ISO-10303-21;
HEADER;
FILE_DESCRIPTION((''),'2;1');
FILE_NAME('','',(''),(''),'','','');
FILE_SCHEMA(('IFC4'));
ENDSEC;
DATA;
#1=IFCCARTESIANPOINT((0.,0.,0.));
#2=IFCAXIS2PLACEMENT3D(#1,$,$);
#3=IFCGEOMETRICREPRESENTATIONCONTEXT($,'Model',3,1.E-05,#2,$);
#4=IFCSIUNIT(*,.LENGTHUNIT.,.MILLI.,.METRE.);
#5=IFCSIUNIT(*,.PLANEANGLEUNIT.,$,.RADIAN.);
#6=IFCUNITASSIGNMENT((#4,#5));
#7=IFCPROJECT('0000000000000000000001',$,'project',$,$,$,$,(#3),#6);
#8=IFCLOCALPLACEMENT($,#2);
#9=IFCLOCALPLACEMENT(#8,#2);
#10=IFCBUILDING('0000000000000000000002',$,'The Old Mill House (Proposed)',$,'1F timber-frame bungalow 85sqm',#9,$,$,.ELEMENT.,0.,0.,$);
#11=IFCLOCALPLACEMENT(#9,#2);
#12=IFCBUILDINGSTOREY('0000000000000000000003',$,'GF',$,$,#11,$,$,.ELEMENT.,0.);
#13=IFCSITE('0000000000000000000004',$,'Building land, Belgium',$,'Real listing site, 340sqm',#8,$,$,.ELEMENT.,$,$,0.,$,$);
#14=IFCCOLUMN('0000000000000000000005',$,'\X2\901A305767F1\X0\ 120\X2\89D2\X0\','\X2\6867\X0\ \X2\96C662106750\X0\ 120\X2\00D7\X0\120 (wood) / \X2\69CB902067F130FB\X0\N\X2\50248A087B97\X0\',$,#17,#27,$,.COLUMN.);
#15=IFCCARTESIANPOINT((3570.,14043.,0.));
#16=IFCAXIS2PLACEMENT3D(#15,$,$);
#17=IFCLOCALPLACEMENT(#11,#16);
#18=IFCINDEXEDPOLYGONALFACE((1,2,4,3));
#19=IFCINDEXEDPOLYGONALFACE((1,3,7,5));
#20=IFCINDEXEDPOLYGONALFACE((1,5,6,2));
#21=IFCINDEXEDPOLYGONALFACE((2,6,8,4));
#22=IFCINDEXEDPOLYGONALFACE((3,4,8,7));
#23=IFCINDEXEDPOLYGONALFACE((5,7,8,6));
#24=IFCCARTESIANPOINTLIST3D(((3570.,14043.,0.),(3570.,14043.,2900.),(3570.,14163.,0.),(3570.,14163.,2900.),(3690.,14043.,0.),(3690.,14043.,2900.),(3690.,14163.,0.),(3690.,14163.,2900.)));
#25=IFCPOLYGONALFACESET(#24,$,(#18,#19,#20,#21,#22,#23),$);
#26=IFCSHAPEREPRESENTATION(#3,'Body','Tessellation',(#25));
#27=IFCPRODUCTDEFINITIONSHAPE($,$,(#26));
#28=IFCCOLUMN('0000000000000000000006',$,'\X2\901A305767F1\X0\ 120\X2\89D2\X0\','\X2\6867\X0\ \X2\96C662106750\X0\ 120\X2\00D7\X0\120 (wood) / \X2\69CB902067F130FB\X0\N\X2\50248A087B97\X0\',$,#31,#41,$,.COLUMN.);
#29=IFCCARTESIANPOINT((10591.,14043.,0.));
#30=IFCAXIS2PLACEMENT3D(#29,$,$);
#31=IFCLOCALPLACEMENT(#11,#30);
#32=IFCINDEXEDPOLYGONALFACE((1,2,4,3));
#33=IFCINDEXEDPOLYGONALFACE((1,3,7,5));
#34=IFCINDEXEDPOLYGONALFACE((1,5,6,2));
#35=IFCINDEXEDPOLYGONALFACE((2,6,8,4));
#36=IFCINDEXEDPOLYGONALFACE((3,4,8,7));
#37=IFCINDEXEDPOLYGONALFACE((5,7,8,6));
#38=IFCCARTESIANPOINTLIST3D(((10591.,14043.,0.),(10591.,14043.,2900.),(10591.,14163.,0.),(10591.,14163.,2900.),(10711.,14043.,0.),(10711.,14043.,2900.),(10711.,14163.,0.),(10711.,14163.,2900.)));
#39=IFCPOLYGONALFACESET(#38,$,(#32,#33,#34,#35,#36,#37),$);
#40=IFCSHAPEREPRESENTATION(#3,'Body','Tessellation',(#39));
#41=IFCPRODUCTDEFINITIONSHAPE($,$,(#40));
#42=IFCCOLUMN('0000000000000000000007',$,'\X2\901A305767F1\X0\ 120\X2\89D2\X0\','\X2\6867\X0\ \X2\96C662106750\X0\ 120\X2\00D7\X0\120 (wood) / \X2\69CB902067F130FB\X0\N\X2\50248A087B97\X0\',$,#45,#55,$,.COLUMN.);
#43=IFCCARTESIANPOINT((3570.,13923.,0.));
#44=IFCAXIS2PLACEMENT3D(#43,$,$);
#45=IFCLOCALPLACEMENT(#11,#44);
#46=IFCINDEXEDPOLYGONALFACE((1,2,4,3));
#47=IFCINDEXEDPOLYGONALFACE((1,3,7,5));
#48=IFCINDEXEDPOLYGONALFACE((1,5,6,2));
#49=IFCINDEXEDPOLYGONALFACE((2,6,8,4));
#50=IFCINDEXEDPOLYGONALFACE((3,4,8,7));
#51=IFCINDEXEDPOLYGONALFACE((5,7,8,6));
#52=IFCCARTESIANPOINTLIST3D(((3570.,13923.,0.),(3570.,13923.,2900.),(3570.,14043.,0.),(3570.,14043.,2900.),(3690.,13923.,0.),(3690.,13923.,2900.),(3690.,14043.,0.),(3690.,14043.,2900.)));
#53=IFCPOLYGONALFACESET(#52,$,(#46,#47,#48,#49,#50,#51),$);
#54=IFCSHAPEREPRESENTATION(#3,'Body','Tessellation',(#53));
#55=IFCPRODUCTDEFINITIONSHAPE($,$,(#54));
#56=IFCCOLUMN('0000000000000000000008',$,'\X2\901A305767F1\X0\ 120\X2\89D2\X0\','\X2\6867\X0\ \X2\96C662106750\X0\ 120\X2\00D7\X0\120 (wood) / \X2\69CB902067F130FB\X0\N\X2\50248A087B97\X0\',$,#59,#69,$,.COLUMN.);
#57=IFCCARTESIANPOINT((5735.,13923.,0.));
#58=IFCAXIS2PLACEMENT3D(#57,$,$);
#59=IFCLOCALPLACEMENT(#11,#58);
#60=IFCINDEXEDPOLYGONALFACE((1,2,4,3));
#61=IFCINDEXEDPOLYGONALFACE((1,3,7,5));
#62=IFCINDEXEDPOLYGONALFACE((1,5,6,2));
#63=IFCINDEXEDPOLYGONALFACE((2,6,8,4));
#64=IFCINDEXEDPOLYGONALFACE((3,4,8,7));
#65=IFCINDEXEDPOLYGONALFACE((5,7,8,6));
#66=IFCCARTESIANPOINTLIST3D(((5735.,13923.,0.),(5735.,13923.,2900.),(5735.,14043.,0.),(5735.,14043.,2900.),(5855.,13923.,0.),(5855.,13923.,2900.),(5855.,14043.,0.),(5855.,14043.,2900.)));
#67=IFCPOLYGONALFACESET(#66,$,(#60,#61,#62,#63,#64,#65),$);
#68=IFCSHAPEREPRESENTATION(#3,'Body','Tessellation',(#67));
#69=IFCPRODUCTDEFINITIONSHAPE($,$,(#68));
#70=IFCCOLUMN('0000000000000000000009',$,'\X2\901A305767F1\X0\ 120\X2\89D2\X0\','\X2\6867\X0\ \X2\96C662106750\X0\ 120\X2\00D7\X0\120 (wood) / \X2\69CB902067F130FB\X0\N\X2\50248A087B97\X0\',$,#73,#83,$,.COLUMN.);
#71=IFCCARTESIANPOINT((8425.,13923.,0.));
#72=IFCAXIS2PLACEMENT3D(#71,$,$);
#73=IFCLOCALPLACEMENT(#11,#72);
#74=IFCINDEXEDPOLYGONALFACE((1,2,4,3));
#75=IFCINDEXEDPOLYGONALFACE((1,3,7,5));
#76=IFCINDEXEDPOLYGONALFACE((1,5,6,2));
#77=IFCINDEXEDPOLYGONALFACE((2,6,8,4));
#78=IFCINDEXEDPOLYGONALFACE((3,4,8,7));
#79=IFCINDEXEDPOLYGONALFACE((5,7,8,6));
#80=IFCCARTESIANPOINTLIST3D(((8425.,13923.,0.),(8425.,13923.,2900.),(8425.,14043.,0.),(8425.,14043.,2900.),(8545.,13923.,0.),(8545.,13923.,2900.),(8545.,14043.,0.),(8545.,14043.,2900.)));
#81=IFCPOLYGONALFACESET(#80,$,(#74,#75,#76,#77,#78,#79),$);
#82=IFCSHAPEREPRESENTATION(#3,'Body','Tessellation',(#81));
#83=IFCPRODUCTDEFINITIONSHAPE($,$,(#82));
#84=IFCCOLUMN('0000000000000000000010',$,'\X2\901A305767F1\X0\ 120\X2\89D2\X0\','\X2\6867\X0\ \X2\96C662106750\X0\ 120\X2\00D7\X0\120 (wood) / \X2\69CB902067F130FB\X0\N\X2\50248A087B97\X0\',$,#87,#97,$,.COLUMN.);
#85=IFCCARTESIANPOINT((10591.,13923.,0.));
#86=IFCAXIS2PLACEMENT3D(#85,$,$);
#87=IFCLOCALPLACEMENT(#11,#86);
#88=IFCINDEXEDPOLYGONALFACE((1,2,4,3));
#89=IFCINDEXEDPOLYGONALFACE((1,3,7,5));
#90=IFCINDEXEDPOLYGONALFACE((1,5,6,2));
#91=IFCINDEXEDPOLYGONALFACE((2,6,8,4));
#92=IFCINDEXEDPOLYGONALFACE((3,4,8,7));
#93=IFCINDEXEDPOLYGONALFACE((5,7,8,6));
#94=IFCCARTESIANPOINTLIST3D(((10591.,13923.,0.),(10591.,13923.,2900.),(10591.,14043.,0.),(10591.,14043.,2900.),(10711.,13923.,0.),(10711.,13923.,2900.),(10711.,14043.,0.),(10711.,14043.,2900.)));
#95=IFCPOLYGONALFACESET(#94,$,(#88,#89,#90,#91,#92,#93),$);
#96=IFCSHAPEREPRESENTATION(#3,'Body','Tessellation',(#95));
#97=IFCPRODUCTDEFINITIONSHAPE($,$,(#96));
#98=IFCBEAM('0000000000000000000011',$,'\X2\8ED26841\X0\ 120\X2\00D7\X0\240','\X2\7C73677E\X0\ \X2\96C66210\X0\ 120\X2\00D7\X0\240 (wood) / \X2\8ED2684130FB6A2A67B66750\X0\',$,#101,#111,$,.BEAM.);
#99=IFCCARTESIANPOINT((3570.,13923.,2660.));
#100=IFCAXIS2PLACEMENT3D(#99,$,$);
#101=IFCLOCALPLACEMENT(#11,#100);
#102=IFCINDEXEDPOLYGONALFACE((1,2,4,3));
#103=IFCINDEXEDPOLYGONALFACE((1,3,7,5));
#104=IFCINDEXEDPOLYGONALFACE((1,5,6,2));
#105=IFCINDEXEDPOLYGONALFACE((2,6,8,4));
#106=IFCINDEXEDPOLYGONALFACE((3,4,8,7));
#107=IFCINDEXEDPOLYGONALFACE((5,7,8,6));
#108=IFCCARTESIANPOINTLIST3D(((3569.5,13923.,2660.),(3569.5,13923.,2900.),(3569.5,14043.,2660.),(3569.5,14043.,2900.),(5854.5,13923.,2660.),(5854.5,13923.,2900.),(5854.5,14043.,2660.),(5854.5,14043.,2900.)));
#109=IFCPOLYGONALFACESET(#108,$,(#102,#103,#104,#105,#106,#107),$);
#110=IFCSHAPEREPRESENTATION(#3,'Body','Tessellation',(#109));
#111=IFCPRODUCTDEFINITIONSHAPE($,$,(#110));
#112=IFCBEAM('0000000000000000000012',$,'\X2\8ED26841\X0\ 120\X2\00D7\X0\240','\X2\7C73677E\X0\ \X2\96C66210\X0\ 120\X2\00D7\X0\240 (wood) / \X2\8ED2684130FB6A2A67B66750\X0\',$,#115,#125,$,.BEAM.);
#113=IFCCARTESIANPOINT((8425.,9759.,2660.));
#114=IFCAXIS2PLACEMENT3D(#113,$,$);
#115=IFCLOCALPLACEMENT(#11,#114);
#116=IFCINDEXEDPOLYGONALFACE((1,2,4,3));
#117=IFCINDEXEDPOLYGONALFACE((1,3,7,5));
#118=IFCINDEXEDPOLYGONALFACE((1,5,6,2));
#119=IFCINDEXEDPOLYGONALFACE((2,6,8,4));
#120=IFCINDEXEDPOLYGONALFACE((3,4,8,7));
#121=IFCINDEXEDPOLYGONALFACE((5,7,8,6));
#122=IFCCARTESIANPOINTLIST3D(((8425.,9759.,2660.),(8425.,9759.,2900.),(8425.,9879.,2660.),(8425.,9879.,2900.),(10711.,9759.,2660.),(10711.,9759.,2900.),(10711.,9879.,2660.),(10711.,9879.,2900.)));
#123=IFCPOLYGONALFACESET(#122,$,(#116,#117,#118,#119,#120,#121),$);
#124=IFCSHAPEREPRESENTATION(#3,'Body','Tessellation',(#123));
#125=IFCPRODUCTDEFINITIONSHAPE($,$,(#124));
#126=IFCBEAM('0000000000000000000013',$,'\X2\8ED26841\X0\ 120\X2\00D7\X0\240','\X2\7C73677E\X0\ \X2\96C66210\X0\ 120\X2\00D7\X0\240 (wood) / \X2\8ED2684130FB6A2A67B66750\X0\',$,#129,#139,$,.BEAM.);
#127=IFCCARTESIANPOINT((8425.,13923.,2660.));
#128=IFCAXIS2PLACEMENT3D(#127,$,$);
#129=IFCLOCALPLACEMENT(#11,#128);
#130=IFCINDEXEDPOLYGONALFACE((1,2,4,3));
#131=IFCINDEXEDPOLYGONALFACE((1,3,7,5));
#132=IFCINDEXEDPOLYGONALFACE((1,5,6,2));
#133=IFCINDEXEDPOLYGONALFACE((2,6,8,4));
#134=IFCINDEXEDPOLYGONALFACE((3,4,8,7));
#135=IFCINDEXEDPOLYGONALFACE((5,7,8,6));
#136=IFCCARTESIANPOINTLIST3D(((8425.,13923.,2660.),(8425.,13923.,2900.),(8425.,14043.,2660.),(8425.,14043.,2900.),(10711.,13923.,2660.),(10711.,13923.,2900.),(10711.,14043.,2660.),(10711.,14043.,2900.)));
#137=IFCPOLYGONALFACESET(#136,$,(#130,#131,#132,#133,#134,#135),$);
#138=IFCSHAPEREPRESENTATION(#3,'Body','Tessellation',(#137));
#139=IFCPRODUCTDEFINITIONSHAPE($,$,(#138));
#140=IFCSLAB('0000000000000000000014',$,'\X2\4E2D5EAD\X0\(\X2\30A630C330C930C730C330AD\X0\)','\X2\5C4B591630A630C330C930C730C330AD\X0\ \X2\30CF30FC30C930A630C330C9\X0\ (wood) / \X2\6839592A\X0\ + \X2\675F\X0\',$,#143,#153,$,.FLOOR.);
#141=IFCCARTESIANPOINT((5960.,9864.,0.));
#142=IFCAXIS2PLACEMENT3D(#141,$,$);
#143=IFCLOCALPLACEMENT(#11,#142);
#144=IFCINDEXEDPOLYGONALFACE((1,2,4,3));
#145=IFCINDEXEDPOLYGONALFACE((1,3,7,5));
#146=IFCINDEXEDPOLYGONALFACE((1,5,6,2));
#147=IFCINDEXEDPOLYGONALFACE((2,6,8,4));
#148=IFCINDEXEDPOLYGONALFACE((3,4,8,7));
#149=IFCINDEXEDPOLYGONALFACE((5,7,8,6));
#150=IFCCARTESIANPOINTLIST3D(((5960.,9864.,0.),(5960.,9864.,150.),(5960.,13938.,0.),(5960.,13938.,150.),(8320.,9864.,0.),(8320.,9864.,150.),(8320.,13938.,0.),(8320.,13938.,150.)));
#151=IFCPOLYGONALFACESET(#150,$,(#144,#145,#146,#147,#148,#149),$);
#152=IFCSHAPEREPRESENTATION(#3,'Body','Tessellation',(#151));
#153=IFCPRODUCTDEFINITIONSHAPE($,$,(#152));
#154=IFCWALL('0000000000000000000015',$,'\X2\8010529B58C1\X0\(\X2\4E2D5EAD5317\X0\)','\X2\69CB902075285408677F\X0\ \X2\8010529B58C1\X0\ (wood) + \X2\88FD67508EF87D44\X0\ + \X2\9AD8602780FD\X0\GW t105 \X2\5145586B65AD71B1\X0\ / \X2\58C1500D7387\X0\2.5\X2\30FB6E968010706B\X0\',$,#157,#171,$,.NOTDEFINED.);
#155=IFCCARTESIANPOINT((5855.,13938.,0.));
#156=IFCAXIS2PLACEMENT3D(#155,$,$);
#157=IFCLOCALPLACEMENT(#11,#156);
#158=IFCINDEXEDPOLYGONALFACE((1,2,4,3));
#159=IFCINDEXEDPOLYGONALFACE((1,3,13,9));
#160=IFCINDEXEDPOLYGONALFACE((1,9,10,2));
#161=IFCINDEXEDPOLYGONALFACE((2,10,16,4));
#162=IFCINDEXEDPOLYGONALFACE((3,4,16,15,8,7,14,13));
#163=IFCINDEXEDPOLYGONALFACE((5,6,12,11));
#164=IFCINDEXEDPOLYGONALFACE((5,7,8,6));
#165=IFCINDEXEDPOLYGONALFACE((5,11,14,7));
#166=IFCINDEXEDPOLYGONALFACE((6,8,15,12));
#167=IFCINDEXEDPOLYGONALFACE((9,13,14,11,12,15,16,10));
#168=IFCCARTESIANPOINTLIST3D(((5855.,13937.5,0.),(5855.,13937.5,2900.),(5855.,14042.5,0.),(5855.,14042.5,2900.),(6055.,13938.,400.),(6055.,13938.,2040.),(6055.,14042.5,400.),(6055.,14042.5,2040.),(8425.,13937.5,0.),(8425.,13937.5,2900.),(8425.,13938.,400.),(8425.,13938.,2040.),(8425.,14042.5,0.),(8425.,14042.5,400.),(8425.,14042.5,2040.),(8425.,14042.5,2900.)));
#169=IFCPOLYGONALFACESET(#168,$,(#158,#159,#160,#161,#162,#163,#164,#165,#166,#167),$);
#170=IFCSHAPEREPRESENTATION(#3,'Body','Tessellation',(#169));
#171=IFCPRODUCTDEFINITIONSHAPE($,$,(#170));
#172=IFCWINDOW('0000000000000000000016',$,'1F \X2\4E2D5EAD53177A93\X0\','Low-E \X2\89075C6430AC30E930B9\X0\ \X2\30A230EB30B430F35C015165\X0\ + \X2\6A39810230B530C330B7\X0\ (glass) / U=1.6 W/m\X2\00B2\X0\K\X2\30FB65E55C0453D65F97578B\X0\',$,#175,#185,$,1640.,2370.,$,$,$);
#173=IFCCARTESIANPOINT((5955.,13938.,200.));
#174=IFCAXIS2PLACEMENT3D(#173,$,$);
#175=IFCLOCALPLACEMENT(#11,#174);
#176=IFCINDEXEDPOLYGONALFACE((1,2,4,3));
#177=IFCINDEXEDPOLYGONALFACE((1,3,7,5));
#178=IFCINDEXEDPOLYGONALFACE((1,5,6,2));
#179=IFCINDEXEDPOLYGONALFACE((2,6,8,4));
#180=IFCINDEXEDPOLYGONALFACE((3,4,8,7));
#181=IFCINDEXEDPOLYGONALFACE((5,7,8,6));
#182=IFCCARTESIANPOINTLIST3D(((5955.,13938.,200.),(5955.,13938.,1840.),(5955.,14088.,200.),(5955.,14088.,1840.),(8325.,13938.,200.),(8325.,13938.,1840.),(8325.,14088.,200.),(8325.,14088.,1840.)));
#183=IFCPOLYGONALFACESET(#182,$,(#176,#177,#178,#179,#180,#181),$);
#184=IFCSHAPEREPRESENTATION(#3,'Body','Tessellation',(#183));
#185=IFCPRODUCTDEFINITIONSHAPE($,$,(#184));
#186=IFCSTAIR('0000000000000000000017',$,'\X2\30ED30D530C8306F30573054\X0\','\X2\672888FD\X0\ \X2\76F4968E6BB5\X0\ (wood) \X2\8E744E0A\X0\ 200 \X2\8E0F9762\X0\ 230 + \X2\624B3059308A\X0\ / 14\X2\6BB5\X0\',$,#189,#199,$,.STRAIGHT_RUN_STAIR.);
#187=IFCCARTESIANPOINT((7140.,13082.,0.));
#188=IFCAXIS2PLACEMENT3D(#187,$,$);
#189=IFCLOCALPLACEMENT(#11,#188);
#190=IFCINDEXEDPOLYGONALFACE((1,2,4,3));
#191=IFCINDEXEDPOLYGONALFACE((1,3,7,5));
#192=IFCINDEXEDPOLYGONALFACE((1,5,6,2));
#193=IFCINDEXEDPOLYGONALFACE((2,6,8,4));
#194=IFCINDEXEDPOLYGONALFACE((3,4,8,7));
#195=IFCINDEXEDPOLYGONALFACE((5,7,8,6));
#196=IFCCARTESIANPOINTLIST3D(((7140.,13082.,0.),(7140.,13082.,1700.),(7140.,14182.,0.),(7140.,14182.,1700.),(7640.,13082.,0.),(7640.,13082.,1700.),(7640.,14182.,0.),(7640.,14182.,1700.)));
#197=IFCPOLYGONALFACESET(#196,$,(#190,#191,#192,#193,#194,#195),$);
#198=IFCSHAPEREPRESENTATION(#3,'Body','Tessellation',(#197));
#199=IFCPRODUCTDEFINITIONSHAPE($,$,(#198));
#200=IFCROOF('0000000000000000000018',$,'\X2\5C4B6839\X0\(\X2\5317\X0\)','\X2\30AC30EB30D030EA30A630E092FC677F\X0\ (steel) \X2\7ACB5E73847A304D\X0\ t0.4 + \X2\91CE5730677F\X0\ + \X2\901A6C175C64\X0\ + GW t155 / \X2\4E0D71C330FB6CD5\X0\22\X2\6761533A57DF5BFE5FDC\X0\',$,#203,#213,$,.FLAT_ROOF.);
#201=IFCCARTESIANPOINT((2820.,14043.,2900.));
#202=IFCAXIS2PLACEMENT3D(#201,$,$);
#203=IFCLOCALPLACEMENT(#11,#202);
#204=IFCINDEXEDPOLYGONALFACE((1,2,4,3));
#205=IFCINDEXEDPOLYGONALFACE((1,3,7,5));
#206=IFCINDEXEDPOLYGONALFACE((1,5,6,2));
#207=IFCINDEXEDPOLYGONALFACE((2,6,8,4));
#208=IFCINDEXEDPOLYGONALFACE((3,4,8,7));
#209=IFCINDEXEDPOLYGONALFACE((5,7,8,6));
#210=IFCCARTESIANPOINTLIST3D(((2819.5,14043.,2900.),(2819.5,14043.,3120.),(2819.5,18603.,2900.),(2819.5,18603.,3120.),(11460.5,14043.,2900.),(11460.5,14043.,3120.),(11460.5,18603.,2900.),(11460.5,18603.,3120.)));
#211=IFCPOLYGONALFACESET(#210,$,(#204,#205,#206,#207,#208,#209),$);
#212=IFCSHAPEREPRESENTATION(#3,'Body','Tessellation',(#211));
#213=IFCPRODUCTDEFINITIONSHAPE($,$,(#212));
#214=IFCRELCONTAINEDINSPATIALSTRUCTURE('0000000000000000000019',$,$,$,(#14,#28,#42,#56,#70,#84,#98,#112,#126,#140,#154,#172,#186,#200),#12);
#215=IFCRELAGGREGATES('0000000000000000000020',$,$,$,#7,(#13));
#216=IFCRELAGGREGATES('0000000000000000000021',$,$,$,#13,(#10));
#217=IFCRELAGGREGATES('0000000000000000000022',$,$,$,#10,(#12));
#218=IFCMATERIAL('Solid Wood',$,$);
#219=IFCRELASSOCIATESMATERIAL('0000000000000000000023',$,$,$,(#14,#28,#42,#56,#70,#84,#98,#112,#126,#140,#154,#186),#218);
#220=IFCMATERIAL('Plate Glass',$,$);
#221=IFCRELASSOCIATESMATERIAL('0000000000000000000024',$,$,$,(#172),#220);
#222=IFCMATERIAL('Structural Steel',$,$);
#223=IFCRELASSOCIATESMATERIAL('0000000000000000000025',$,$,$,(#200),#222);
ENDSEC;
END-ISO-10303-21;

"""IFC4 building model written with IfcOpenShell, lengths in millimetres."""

from ifc_helpers import new_model, si_unit, frame, frame_2d, origin, place, context, project, spatial, rectangle, extrude, material, element, fill, save


model = new_model("IFC4")

# Units and contexts
model_context = context("Model", 3, precision=1e-05, world=origin())
ifc_project = project(units=[si_unit("LENGTHUNIT", "METRE", prefix="MILLI"), si_unit("PLANEANGLEUNIT", "RADIAN")], contexts=[model_context])

# Site, building, storey
site_placement = place(None, origin())
site = spatial("IfcSite", under=ifc_project, at=site_placement, Name="Building land, Belgium", ObjectType="Real listing site, 340sqm", CompositionType="ELEMENT", RefElevation=0.0)
building_placement = place(site_placement, origin())
building = spatial("IfcBuilding", under=site, at=building_placement, Name="The Old Mill House (Proposed)", ObjectType="1F timber-frame bungalow 85sqm", CompositionType="ELEMENT", ElevationOfRefHeight=0.0, ElevationOfTerrain=0.0)
storey_placement = place(building_placement, origin())
storey = spatial("IfcBuildingStorey", under=building, at=storey_placement, Name="GF", CompositionType="ELEMENT", Elevation=0.0)

# Columns
ifc_material_1 = material(Name="Solid Wood")
column_1_placement = place(storey_placement, frame((3570.0, 14043.0, 0.0)))
element("IfcColumn", 1, at=column_1_placement, inside=storey, material=ifc_material_1, Name="通し柱 120角", Description="桧 集成材 120×120 (wood) / 構造柱・N値計算", PredefinedType="COLUMN", context=model_context, shape_type="SweptSolid", body=[
    extrude(rectangle(XDim=120.0, YDim=120.0, at=frame_2d((60.0, 60.0))), frame((3570.0, 14043.0, 0.0)), (0.0, 0.0, 1.0), 2900.0),
])
column_2_placement = place(storey_placement, frame((10591.0, 14043.0, 0.0)))
element("IfcColumn", 2, at=column_2_placement, inside=storey, material=ifc_material_1, Name="通し柱 120角", Description="桧 集成材 120×120 (wood) / 構造柱・N値計算", PredefinedType="COLUMN", context=model_context, shape_type="SweptSolid", body=[
    extrude(rectangle(XDim=120.0, YDim=120.0, at=frame_2d((60.0, 60.0))), frame((10591.0, 14043.0, 0.0)), (0.0, 0.0, 1.0), 2900.0),
])
column_3_placement = place(storey_placement, frame((3570.0, 13923.0, 0.0)))
element("IfcColumn", 3, at=column_3_placement, inside=storey, material=ifc_material_1, Name="通し柱 120角", Description="桧 集成材 120×120 (wood) / 構造柱・N値計算", PredefinedType="COLUMN", context=model_context, shape_type="SweptSolid", body=[
    extrude(rectangle(XDim=120.0, YDim=120.0, at=frame_2d((60.0, 60.0))), frame((3570.0, 13923.0, 0.0)), (0.0, 0.0, 1.0), 2900.0),
])
column_4_placement = place(storey_placement, frame((5735.0, 13923.0, 0.0)))
element("IfcColumn", 4, at=column_4_placement, inside=storey, material=ifc_material_1, Name="通し柱 120角", Description="桧 集成材 120×120 (wood) / 構造柱・N値計算", PredefinedType="COLUMN", context=model_context, shape_type="SweptSolid", body=[
    extrude(rectangle(XDim=120.0, YDim=120.0, at=frame_2d((60.0, 60.0))), frame((5735.0, 13923.0, 0.0)), (0.0, 0.0, 1.0), 2900.0),
])
column_5_placement = place(storey_placement, frame((8425.0, 13923.0, 0.0)))
element("IfcColumn", 5, at=column_5_placement, inside=storey, material=ifc_material_1, Name="通し柱 120角", Description="桧 集成材 120×120 (wood) / 構造柱・N値計算", PredefinedType="COLUMN", context=model_context, shape_type="SweptSolid", body=[
    extrude(rectangle(XDim=120.0, YDim=120.0, at=frame_2d((60.0, 60.0))), frame((8425.0, 13923.0, 0.0)), (0.0, 0.0, 1.0), 2900.0),
])
column_6_placement = place(storey_placement, frame((10591.0, 13923.0, 0.0)))
element("IfcColumn", 6, at=column_6_placement, inside=storey, material=ifc_material_1, Name="通し柱 120角", Description="桧 集成材 120×120 (wood) / 構造柱・N値計算", PredefinedType="COLUMN", context=model_context, shape_type="SweptSolid", body=[
    extrude(rectangle(XDim=120.0, YDim=120.0, at=frame_2d((60.0, 60.0))), frame((10591.0, 13923.0, 0.0)), (0.0, 0.0, 1.0), 2900.0),
])

# Beams
beam_1_placement = place(storey_placement, frame((3570.0, 13923.0, 2660.0)))
element("IfcBeam", 7, at=beam_1_placement, inside=storey, material=ifc_material_1, Name="軒桁 120×240", Description="米松 集成 120×240 (wood) / 軒桁・横架材", PredefinedType="BEAM", context=model_context, shape_type="SweptSolid", body=[
    extrude(rectangle(XDim=2285.0, YDim=120.0, at=frame_2d((1142.0, 60.0))), frame((3570.0, 13923.0, 2660.0)), (0.0, 0.0, 1.0), 240.0),
])
beam_2_placement = place(storey_placement, frame((8425.0, 9759.0, 2660.0)))
element("IfcBeam", 8, at=beam_2_placement, inside=storey, material=ifc_material_1, Name="軒桁 120×240", Description="米松 集成 120×240 (wood) / 軒桁・横架材", PredefinedType="BEAM", context=model_context, shape_type="SweptSolid", body=[
    extrude(rectangle(XDim=2286.0, YDim=120.0, at=frame_2d((1143.0, 60.0))), frame((8425.0, 9759.0, 2660.0)), (0.0, 0.0, 1.0), 240.0),
])
beam_3_placement = place(storey_placement, frame((8425.0, 13923.0, 2660.0)))
element("IfcBeam", 9, at=beam_3_placement, inside=storey, material=ifc_material_1, Name="軒桁 120×240", Description="米松 集成 120×240 (wood) / 軒桁・横架材", PredefinedType="BEAM", context=model_context, shape_type="SweptSolid", body=[
    extrude(rectangle(XDim=2286.0, YDim=120.0, at=frame_2d((1143.0, 60.0))), frame((8425.0, 13923.0, 2660.0)), (0.0, 0.0, 1.0), 240.0),
])

# Slab
slab_1_placement = place(storey_placement, frame((5960.0, 9864.0, 0.0)))
element("IfcSlab", 10, at=slab_1_placement, inside=storey, material=ifc_material_1, Name="中庭(ウッドデッキ)", Description="屋外ウッドデッキ ハードウッド (wood) / 根太 + 束", PredefinedType="FLOOR", context=model_context, shape_type="SweptSolid", body=[
    extrude(rectangle(XDim=2360.0, YDim=4074.0, at=frame_2d((1180.0, 2037.0))), frame((5960.0, 9864.0, 0.0)), (0.0, 0.0, 1.0), 150.0),
])

# Wall, opening, window
wall_placement = place(storey_placement, frame((5855.0, 13938.0, 0.0)))
wall = element("IfcWall", 11, at=wall_placement, inside=storey, material=ifc_material_1, Name="耐力壁(中庭北)", Description="構造用合板 耐力壁 (wood) + 製材軸組 + 高性能GW t105 充填断熱 / 壁倍率2.5・準耐火", PredefinedType="NOTDEFINED", context=model_context, shape_type="SweptSolid", body=[
    extrude(rectangle(XDim=2570.0, YDim=105.0, at=frame_2d((1285.0, 52.0))), frame((5855.0, 13938.0, 0.0)), (0.0, 0.0, 1.0), 2900.0),
])
opening_placement = place(storey_placement, frame((5955.0, 13938.0, 200.0)))
opening = element("IfcOpeningElement", 12, at=opening_placement, cuts=wall, PredefinedType="NOTDEFINED", context=model_context, shape_type="SweptSolid", body=[
    extrude(rectangle(XDim=2370.0, YDim=150.0, at=frame_2d((1185.0, 75.0))), frame((5955.0, 13938.0, 200.0)), (0.0, 0.0, 1.0), 1640.0),
])
ifc_material_2 = material(Name="Plate Glass")
window_placement = place(storey_placement, frame((5955.0, 13938.0, 200.0)))
window = element("IfcWindow", 13, at=window_placement, inside=storey, material=ifc_material_2, Name="1F 中庭北窓", Description="Low-E 複層ガラス アルゴン封入 + 樹脂サッシ (glass) / U=1.6 W/m²K・日射取得型", OverallHeight=1640.0, OverallWidth=2370.0, context=model_context, shape_type="SweptSolid", body=[
    extrude(rectangle(XDim=2370.0, YDim=150.0, at=frame_2d((1185.0, 75.0))), frame((5955.0, 13938.0, 200.0)), (0.0, 0.0, 1.0), 1640.0),
])
fill(opening, window)

# Stair
stair_placement = place(storey_placement, frame((7140.0, 13082.0, 0.0)))
element("IfcStair", 14, at=stair_placement, inside=storey, material=ifc_material_1, Name="ロフトはしご", Description="木製 直階段 (wood) 蹴上 200 踏面 230 + 手すり / 14段", PredefinedType="STRAIGHT_RUN_STAIR", context=model_context, shape_type="SweptSolid", body=[
    extrude(rectangle(XDim=500.0, YDim=1100.0, at=frame_2d((250.0, 550.0))), frame((7140.0, 13082.0, 0.0)), (0.0, 0.0, 1.0), 1700.0),
])

# Roof
ifc_material_3 = material(Name="Structural Steel")
roof_placement = place(storey_placement, frame((2820.0, 14043.0, 2900.0)))
element("IfcRoof", 15, at=roof_placement, inside=storey, material=ifc_material_3, Name="屋根(北)", Description="ガルバリウム鋼板 (steel) 立平葺き t0.4 + 野地板 + 通気層 + GW t155 / 不燃・法22条区域対応", PredefinedType="FLAT_ROOF", context=model_context, shape_type="SweptSolid", body=[
    extrude(rectangle(XDim=8641.0, YDim=4560.0, at=frame_2d((4320.0, 2280.0))), frame((2820.0, 14043.0, 2900.0)), (0.0, 0.0, 1.0), 220.0),
])

save(model, "model.ifc")
